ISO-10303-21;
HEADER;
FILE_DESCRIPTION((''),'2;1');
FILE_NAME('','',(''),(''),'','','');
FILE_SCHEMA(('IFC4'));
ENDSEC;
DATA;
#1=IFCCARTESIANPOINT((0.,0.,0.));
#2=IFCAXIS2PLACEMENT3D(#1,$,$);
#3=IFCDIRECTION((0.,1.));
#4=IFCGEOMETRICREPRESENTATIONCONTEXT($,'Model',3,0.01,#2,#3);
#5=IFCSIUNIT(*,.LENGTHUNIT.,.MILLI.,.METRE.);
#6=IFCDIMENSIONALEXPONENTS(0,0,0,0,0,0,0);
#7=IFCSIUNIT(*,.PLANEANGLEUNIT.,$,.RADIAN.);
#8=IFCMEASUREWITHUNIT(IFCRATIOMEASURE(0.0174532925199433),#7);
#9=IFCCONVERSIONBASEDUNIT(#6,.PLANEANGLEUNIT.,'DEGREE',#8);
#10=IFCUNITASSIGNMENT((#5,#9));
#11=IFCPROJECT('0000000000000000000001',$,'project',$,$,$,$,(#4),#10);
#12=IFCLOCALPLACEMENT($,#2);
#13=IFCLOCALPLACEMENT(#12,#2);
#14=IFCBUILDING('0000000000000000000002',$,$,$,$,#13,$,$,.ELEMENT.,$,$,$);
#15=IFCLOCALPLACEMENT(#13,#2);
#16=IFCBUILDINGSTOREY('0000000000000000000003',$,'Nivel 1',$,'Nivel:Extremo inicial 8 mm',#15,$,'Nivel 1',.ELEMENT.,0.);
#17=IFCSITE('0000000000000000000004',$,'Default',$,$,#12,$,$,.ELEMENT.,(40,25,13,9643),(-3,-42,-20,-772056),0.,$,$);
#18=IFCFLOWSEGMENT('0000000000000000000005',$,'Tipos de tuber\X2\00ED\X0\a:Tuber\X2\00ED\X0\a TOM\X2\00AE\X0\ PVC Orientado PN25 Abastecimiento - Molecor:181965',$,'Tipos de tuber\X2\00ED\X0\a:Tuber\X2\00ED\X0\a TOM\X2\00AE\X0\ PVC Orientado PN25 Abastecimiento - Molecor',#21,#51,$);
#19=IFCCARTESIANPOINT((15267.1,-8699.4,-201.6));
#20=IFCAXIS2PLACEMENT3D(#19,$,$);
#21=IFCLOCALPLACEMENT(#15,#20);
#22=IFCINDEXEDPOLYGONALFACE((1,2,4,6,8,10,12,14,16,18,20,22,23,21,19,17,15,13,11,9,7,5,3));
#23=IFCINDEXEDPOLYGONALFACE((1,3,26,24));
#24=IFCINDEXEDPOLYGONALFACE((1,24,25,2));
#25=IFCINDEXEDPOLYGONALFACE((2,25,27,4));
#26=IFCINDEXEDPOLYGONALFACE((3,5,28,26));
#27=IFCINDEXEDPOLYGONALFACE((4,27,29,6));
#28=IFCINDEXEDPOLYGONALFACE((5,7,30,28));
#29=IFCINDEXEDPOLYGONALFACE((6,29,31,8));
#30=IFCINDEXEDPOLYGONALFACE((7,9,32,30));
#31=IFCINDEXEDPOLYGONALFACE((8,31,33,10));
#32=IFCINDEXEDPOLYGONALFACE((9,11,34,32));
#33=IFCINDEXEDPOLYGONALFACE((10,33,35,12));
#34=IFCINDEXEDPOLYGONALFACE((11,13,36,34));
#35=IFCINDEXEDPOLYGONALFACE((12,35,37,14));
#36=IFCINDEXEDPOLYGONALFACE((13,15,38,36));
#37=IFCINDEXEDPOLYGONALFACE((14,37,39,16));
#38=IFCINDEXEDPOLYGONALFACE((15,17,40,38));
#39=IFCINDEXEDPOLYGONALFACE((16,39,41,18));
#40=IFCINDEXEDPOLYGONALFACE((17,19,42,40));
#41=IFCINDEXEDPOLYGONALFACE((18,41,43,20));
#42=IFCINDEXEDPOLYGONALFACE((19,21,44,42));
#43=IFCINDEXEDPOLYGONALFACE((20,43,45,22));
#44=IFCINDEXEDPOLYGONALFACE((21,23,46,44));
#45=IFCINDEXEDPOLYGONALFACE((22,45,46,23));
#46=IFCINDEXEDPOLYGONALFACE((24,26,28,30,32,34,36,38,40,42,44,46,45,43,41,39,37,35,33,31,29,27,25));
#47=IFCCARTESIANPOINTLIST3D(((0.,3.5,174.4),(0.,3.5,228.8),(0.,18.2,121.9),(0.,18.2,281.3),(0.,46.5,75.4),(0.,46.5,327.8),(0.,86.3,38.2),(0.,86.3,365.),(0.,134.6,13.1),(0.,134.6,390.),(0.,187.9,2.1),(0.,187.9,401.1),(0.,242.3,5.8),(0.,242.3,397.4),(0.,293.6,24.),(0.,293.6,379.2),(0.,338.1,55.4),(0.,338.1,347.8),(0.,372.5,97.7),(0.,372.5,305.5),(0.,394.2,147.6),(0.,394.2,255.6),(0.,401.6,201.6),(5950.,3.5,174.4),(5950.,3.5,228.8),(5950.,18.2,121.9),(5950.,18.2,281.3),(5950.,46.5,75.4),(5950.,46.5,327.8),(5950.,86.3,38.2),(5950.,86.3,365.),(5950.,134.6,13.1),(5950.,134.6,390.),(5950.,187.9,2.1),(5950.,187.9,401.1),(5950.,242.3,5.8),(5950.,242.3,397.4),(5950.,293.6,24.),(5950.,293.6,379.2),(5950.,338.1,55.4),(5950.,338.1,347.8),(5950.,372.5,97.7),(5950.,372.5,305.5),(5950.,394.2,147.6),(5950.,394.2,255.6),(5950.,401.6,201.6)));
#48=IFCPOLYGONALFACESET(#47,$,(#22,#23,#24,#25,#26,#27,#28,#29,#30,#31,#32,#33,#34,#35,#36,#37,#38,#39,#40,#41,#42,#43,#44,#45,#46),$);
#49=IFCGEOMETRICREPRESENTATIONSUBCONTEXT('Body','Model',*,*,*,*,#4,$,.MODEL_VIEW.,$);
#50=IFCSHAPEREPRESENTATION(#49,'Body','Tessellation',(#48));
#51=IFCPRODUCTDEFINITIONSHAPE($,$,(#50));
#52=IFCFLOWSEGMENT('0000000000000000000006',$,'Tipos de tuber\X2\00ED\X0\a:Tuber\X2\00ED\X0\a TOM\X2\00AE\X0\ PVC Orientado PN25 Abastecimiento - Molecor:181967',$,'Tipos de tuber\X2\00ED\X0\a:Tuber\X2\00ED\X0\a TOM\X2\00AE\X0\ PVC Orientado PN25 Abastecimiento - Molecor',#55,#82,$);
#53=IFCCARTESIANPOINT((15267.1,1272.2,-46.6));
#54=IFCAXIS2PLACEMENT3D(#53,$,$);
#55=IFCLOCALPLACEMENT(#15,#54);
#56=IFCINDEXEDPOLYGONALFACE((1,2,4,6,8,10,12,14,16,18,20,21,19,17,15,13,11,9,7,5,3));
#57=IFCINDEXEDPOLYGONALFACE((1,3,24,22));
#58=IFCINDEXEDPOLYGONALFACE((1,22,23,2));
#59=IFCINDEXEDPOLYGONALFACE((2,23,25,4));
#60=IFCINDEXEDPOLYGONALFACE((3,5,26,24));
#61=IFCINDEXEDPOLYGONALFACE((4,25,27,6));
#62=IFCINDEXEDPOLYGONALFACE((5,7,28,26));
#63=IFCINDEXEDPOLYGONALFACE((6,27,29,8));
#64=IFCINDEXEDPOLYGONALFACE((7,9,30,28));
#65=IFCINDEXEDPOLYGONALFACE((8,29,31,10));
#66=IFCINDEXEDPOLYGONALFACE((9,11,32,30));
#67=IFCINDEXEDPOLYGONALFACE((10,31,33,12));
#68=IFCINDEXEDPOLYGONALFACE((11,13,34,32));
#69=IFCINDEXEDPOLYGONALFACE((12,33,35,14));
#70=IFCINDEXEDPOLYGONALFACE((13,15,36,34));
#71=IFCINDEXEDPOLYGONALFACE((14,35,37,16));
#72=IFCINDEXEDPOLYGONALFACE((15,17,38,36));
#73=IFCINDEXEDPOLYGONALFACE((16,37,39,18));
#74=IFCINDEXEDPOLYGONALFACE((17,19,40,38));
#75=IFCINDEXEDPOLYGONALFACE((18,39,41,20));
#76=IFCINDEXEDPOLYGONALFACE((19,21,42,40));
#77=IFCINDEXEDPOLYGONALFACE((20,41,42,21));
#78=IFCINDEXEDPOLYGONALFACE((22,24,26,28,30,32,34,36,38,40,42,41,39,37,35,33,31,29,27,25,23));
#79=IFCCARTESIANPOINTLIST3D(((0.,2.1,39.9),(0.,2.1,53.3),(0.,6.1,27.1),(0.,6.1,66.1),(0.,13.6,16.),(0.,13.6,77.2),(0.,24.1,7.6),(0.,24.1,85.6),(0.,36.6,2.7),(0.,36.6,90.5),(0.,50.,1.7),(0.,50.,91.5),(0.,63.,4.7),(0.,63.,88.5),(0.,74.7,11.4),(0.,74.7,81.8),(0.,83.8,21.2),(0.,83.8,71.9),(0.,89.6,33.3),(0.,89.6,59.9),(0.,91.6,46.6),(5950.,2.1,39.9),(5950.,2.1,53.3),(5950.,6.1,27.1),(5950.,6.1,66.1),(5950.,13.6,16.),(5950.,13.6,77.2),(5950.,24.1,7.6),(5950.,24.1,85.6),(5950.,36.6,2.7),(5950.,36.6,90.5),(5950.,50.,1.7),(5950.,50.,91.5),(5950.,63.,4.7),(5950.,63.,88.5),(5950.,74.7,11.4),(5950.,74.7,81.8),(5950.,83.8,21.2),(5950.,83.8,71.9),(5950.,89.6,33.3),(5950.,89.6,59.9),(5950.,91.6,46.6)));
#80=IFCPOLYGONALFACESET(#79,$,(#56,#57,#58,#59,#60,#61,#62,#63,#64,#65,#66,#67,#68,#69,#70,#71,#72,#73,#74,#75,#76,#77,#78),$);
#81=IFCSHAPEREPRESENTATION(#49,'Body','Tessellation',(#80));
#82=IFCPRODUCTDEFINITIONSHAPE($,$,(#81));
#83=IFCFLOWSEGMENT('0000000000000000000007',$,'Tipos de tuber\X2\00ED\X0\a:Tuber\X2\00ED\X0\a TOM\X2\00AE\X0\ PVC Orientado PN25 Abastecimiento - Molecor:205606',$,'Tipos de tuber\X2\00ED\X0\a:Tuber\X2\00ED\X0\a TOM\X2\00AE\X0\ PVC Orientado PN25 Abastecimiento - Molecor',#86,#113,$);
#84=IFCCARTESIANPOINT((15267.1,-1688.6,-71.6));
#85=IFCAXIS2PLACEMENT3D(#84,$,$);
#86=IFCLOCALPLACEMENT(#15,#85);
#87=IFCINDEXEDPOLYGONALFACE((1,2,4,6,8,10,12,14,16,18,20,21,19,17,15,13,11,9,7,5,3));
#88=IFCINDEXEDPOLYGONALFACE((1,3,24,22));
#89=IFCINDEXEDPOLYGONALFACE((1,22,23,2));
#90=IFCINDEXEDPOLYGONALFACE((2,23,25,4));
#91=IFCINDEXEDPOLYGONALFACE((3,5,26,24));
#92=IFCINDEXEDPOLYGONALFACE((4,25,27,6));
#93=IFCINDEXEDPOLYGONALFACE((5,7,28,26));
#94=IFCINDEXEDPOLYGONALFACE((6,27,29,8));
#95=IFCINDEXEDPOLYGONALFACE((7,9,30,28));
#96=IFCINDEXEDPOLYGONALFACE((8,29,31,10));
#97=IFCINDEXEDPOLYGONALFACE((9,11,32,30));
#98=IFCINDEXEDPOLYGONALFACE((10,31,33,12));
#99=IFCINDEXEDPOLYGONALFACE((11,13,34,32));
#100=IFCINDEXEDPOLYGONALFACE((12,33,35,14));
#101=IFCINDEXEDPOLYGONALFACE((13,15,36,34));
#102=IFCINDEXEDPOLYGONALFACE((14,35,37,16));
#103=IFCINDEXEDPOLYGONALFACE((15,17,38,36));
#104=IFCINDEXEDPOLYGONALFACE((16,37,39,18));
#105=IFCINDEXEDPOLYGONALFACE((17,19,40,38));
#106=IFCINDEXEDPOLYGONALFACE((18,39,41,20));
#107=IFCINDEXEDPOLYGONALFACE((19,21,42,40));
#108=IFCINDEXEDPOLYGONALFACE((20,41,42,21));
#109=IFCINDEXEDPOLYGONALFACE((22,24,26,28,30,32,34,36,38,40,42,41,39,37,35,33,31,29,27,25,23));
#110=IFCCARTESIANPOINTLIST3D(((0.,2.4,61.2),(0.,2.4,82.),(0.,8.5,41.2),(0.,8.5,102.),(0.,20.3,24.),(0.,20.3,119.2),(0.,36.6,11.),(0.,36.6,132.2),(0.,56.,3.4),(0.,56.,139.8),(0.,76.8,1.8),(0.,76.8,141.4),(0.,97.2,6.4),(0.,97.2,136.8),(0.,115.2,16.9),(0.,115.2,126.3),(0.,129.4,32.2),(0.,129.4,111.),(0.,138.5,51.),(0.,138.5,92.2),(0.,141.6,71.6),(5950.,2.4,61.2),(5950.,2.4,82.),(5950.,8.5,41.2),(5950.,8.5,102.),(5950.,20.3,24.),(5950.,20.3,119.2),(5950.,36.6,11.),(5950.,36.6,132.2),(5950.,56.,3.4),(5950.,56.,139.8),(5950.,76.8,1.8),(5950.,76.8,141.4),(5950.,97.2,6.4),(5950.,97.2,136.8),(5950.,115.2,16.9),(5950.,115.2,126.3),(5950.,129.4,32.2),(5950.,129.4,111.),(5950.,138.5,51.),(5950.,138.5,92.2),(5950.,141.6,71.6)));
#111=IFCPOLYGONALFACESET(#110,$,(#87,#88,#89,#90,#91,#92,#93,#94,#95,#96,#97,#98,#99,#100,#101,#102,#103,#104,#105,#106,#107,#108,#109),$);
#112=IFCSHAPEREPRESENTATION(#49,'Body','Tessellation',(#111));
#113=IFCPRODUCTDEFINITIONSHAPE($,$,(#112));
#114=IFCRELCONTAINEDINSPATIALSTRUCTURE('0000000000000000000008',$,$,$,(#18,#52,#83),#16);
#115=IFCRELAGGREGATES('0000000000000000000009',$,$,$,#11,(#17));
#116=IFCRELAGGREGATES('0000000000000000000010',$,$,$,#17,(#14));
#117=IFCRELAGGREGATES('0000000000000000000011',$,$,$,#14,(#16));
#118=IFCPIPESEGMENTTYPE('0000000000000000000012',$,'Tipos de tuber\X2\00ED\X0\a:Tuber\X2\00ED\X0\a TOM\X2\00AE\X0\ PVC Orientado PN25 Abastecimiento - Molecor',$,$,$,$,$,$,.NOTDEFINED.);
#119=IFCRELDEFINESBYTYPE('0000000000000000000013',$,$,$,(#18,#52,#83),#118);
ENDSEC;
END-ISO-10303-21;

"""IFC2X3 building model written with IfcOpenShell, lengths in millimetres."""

from ifc_helpers import new_model, entity, si_unit, converted_unit, direction, frame, frame_2d, origin, place, context, subcontext, project, spatial, circle, extrude, type_object, element, save


model = new_model("IFC2X3")

# Units and contexts
model_context = context("Model", 3, precision=0.01, world=origin(), true_north=direction((0.0, 1.0)))
body_context = subcontext(model_context, "Body", "Model", "MODEL_VIEW")
ifc_project = project(units=[si_unit("LENGTHUNIT", "METRE", prefix="MILLI"), converted_unit("PLANEANGLEUNIT", "DEGREE", entity("IfcRatioMeasure", 0.0174532925199433), si_unit("PLANEANGLEUNIT", "RADIAN"), dimensions=[0, 0, 0, 0, 0, 0, 0])], contexts=[model_context])

# Site, building, storey
site_placement = place(None, origin())
site = spatial("IfcSite", under=ifc_project, at=site_placement, Name="Default", CompositionType="ELEMENT", RefLatitude=(40, 25, 13, 9643), RefLongitude=(-3, -42, -20, -772056), RefElevation=0.0)
building_placement = place(site_placement, origin())
building = spatial("IfcBuilding", under=site, at=building_placement, CompositionType="ELEMENT")
storey_placement = place(building_placement, origin())
storey = spatial("IfcBuildingStorey", under=building, at=storey_placement, Name="Nivel 1", ObjectType="Nivel:Extremo inicial 8 mm", LongName="Nivel 1", CompositionType="ELEMENT", Elevation=0.0)

# Flow segments
pipe_segment_type = type_object("IfcPipeSegmentType", Name="Tipos de tubería:Tubería TOM® PVC Orientado PN25 Abastecimiento - Molecor", PredefinedType="NOTDEFINED")
flow_segment_1_placement = place(storey_placement, frame((15267.1, -8699.4, -201.6)))
element("IfcFlowSegment", 1, at=flow_segment_1_placement, inside=storey, type_object=pipe_segment_type, Name="Tipos de tubería:Tubería TOM® PVC Orientado PN25 Abastecimiento - Molecor:181965", ObjectType="Tipos de tubería:Tubería TOM® PVC Orientado PN25 Abastecimiento - Molecor", context=body_context, shape_type="SweptSolid", body=[
    extrude(circle(Radius=200.0, at=frame_2d((0.0, 0.0), x_axis=(1.0, 0.0))), frame((0.0, 201.6, 201.6), z_axis=(1.0, 0.0, 0.0), x_axis=(0.0, 1.0, 0.0)), (0.0, 0.0, 1.0), 5950.0),
])
flow_segment_2_placement = place(storey_placement, frame((15267.1, 1272.2, -46.6)))
element("IfcFlowSegment", 2, at=flow_segment_2_placement, inside=storey, type_object=pipe_segment_type, Name="Tipos de tubería:Tubería TOM® PVC Orientado PN25 Abastecimiento - Molecor:181967", ObjectType="Tipos de tubería:Tubería TOM® PVC Orientado PN25 Abastecimiento - Molecor", context=body_context, shape_type="SweptSolid", body=[
    extrude(circle(Radius=45.0, at=frame_2d((0.0, 0.0), x_axis=(1.0, 0.0))), frame((0.0, 46.6, 46.6), z_axis=(1.0, 0.0, 0.0), x_axis=(0.0, 1.0, 0.0)), (0.0, 0.0, 1.0), 5950.0),
])
flow_segment_3_placement = place(storey_placement, frame((15267.1, -1688.6, -71.6)))
element("IfcFlowSegment", 3, at=flow_segment_3_placement, inside=storey, type_object=pipe_segment_type, Name="Tipos de tubería:Tubería TOM® PVC Orientado PN25 Abastecimiento - Molecor:205606", ObjectType="Tipos de tubería:Tubería TOM® PVC Orientado PN25 Abastecimiento - Molecor", context=body_context, shape_type="SweptSolid", body=[
    extrude(circle(Radius=70.0, at=frame_2d((0.0, 0.0), x_axis=(1.0, 0.0))), frame((0.0, 71.6, 71.6), z_axis=(1.0, 0.0, 0.0), x_axis=(0.0, 1.0, 0.0)), (0.0, 0.0, 1.0), 5950.0),
])

save(model, "model.ifc")
